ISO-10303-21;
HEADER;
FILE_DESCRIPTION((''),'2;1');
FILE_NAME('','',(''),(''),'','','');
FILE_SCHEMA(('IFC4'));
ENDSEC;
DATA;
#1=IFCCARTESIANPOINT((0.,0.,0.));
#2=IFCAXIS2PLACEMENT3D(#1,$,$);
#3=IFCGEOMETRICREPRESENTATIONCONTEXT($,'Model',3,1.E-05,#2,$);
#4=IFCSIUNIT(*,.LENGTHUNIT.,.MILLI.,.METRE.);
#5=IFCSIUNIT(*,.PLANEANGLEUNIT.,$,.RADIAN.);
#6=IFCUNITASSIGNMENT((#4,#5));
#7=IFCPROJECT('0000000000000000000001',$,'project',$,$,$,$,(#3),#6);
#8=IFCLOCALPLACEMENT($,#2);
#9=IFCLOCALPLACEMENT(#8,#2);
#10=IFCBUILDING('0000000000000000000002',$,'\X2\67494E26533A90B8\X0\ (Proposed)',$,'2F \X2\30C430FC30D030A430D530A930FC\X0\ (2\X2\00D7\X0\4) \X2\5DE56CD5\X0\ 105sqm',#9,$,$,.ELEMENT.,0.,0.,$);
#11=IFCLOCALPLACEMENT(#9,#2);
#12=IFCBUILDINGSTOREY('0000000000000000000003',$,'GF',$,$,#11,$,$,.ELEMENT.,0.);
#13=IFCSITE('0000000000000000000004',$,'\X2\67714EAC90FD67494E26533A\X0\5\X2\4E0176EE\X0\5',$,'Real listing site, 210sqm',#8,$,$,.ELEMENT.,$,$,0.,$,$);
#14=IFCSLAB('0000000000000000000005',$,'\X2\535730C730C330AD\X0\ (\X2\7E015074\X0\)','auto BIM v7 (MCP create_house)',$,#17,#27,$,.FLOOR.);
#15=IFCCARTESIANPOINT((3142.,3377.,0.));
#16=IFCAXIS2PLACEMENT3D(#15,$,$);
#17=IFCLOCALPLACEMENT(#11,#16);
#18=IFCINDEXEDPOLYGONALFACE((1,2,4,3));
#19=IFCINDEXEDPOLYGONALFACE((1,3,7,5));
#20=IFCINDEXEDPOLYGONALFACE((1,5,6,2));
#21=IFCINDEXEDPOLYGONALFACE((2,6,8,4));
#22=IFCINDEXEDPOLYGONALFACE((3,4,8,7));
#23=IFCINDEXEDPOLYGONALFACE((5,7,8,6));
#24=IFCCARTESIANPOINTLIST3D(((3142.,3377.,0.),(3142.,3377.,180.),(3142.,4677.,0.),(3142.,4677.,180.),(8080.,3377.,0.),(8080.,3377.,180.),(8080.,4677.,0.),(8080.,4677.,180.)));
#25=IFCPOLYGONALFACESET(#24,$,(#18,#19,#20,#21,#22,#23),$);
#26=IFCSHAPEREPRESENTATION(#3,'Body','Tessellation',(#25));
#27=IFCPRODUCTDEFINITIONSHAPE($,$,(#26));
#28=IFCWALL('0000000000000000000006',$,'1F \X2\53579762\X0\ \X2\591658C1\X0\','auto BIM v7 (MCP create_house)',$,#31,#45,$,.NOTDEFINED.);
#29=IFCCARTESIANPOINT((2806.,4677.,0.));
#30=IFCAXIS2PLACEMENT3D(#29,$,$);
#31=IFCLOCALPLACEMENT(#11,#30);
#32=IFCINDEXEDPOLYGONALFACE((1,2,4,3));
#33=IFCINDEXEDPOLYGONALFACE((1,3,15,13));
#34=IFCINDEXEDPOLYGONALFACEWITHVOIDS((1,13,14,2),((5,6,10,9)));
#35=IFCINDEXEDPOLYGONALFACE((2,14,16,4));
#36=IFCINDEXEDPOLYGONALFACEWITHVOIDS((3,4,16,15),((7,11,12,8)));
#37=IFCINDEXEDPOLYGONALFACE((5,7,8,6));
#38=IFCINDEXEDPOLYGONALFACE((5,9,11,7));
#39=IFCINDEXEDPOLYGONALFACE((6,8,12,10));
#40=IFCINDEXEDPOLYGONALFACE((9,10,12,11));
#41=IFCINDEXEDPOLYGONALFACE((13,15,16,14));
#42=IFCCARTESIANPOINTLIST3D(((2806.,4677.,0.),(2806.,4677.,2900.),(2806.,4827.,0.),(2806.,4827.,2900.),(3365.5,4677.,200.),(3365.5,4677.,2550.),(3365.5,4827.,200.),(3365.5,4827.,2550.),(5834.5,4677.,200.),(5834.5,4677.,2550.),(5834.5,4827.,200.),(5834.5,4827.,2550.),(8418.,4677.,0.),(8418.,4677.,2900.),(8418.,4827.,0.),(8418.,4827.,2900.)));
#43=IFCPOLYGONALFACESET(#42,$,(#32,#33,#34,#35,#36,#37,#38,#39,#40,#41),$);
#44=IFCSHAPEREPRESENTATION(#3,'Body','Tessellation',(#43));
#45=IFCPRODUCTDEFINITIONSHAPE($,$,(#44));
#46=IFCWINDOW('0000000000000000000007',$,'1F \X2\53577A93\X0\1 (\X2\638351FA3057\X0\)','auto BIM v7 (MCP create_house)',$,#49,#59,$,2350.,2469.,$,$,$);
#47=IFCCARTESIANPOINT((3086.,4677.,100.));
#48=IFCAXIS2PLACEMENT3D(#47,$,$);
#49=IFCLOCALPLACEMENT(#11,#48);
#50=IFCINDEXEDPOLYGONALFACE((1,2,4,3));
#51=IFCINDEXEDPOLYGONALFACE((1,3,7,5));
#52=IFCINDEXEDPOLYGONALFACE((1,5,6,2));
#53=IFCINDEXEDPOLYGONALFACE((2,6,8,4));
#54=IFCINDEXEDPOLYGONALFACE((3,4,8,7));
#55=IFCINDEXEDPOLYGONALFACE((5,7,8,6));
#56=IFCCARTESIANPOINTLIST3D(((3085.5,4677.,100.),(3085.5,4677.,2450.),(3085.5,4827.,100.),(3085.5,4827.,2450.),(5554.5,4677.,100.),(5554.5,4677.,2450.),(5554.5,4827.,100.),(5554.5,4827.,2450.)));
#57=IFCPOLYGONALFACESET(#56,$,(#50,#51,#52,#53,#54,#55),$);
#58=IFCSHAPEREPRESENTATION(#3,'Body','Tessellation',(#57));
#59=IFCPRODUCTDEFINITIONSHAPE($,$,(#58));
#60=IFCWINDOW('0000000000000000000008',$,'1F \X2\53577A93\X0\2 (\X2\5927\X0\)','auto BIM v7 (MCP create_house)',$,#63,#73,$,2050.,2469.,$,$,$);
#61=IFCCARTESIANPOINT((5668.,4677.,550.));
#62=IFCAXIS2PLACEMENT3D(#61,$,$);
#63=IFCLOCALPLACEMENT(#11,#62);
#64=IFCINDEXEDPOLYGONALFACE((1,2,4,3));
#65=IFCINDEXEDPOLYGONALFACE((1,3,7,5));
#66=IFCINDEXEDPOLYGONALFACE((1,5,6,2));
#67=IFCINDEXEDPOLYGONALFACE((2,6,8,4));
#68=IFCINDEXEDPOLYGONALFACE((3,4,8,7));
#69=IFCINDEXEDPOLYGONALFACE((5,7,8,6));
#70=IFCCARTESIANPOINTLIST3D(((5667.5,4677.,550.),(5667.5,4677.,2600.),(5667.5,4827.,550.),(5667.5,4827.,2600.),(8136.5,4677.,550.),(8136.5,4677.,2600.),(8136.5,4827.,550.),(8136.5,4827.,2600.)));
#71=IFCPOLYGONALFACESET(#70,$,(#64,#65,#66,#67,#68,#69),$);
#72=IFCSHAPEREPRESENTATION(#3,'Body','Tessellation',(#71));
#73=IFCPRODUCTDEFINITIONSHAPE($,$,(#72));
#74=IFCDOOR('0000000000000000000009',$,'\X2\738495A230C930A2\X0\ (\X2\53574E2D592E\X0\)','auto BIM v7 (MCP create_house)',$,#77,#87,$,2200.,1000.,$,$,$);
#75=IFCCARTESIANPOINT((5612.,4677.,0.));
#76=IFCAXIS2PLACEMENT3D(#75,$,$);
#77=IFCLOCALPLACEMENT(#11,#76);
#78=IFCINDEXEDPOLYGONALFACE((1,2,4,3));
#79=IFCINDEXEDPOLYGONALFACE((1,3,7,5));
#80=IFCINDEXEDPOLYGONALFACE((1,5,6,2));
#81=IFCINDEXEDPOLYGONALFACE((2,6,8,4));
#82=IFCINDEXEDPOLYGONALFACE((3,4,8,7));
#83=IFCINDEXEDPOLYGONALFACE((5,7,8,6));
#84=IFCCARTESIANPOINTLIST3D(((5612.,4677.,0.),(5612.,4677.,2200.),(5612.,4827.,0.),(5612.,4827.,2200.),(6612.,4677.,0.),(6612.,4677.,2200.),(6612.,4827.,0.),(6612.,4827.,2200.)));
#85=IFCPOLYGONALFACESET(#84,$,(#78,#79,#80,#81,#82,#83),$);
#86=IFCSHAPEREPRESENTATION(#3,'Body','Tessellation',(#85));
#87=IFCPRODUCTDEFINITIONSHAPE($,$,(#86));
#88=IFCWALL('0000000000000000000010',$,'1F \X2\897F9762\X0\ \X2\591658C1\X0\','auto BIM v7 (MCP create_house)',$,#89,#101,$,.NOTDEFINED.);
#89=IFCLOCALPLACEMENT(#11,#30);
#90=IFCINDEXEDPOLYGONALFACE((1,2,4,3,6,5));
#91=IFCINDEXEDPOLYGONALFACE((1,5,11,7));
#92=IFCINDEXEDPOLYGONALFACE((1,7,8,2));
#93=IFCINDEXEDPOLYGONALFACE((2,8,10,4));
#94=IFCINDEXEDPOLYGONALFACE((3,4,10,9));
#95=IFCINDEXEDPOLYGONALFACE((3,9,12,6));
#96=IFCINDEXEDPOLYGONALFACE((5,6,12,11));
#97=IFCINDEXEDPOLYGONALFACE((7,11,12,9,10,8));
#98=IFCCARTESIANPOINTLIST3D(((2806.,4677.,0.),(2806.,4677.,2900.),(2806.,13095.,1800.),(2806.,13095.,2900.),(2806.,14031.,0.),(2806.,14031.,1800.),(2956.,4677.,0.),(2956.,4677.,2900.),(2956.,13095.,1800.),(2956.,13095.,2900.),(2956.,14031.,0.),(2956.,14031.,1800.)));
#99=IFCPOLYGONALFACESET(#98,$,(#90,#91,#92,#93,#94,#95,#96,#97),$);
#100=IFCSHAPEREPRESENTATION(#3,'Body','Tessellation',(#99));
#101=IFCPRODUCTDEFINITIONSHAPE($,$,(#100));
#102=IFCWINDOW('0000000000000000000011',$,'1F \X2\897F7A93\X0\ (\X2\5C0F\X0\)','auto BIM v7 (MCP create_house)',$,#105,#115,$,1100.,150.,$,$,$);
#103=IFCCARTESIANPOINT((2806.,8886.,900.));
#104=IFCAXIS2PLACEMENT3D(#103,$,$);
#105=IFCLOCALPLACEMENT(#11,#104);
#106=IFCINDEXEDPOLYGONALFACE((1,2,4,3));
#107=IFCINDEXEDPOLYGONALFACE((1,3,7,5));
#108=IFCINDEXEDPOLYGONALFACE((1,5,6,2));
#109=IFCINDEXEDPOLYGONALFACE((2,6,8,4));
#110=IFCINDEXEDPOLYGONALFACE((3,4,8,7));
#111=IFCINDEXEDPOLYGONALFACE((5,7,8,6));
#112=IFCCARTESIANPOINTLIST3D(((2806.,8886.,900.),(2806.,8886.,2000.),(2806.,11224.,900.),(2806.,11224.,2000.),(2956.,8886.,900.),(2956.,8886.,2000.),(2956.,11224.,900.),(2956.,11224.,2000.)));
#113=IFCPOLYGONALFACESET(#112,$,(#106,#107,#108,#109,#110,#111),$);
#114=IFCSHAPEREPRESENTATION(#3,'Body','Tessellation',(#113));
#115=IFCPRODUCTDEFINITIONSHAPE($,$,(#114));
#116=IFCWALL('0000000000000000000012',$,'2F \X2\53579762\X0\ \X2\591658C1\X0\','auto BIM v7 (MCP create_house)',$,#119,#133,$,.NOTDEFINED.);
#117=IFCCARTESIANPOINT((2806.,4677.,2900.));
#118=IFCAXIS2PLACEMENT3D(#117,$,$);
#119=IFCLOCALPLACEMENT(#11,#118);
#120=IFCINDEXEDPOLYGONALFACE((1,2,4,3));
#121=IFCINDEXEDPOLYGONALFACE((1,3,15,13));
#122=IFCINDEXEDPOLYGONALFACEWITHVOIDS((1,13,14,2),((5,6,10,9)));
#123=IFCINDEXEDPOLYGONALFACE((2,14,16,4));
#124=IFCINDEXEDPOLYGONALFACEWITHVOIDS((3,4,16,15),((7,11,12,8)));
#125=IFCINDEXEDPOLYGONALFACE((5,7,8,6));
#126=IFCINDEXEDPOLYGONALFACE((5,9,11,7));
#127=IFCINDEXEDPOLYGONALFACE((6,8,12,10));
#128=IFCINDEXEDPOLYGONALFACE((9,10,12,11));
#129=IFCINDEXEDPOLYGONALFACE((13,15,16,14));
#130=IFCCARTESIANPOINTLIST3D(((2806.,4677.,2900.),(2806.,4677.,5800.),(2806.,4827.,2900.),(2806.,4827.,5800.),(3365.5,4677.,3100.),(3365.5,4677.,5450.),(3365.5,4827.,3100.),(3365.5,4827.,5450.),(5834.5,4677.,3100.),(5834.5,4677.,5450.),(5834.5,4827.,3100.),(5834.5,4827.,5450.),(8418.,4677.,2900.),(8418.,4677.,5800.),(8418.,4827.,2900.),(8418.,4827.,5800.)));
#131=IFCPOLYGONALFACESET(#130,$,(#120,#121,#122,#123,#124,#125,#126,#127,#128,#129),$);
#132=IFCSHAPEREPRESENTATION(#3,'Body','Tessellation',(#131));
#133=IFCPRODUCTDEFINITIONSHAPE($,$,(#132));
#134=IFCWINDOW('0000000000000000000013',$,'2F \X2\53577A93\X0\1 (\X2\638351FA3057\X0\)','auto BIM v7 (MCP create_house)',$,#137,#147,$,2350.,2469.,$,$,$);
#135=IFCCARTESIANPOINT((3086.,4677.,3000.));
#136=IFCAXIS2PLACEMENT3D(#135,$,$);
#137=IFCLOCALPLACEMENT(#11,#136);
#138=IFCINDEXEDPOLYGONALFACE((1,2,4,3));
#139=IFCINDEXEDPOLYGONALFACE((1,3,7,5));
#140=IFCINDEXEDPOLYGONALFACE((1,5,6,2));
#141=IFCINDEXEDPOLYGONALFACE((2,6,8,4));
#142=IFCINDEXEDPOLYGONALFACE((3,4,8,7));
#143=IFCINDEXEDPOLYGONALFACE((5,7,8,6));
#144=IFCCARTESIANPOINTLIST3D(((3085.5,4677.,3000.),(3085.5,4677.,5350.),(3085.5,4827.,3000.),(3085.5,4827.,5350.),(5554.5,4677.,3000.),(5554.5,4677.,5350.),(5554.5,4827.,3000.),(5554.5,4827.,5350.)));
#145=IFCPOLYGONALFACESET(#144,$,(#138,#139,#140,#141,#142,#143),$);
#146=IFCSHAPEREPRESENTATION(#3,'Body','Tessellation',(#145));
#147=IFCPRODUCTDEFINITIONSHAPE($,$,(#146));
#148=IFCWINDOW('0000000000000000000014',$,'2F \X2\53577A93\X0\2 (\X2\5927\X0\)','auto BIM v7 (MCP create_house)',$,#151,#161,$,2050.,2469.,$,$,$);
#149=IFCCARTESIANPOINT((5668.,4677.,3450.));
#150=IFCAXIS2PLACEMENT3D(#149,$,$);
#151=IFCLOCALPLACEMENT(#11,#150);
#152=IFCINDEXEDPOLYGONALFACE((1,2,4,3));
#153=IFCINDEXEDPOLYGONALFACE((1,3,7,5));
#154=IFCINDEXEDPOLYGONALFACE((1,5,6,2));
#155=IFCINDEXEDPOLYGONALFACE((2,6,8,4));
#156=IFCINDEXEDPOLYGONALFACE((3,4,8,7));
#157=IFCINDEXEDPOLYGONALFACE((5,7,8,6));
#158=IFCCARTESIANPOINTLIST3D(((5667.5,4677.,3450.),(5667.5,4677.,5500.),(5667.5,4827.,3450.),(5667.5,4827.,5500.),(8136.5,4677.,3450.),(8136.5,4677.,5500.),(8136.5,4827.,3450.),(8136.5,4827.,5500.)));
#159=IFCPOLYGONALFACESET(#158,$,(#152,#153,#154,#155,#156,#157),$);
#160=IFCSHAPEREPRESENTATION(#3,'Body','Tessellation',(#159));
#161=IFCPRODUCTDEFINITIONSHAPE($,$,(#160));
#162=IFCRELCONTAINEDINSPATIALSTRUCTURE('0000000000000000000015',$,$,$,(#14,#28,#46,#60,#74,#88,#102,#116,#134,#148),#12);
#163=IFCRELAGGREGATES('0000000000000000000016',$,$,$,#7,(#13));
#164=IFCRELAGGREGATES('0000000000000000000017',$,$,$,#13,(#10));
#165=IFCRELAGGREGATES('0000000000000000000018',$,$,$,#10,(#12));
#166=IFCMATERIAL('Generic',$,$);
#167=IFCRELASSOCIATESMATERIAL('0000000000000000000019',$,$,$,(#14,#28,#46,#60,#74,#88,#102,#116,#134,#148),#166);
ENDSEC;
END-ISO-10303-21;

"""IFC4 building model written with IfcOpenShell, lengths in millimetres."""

from ifc_helpers import new_model, si_unit, frame, frame_2d, origin, place, context, project, spatial, rectangle, extrude, material, element, fill, save


model = new_model("IFC4")

# Units and contexts
model_context = context("Model", 3, precision=1e-05, world=origin())
ifc_project = project(units=[si_unit("LENGTHUNIT", "METRE", prefix="MILLI"), si_unit("PLANEANGLEUNIT", "RADIAN")], contexts=[model_context])

# Site, building, storey
site_placement = place(None, origin())
site = spatial("IfcSite", under=ifc_project, at=site_placement, Name="東京都杉並区5丁目5", ObjectType="Real listing site, 210sqm", CompositionType="ELEMENT", RefElevation=0.0)
building_placement = place(site_placement, origin())
building = spatial("IfcBuilding", under=site, at=building_placement, Name="杉並区邸 (Proposed)", ObjectType="2F ツーバイフォー (2×4) 工法 105sqm", CompositionType="ELEMENT", ElevationOfRefHeight=0.0, ElevationOfTerrain=0.0)
storey_placement = place(building_placement, origin())
storey = spatial("IfcBuildingStorey", under=building, at=storey_placement, Name="GF", CompositionType="ELEMENT", Elevation=0.0)

# Slab
ifc_material = material(Name="Generic")
slab_1_placement = place(storey_placement, frame((3142.0, 3377.0, 0.0)))
element("IfcSlab", 1, at=slab_1_placement, inside=storey, material=ifc_material, Name="南デッキ (縁側)", Description="auto BIM v7 (MCP create_house)", PredefinedType="FLOOR", context=model_context, shape_type="SweptSolid", body=[
    extrude(rectangle(XDim=4938.0, YDim=1300.0, at=frame_2d((2469.0, 650.0))), frame((3142.0, 3377.0, 0.0)), (0.0, 0.0, 1.0), 180.0),
])

# Wall, openings, windows, door
wall_1_placement = place(storey_placement, frame((2806.0, 4677.0, 0.0)))
wall_1 = element("IfcWall", 2, at=wall_1_placement, inside=storey, material=ifc_material, Name="1F 南面 外壁", Description="auto BIM v7 (MCP create_house)", PredefinedType="NOTDEFINED", context=model_context, shape_type="SweptSolid", body=[
    extrude(rectangle(XDim=5612.0, YDim=150.0, at=frame_2d((2806.0, 75.0))), frame((2806.0, 4677.0, 0.0)), (0.0, 0.0, 1.0), 2900.0),
])
opening_1_placement = place(storey_placement, frame((3086.0, 4677.0, 100.0)))
opening_1 = element("IfcOpeningElement", 3, at=opening_1_placement, cuts=wall_1, PredefinedType="NOTDEFINED", context=model_context, shape_type="SweptSolid", body=[
    extrude(rectangle(XDim=2469.0, YDim=150.0, at=frame_2d((1234.0, 75.0))), frame((3086.0, 4677.0, 100.0)), (0.0, 0.0, 1.0), 2350.0),
])
opening_2_placement = place(storey_placement, frame((5668.0, 4677.0, 550.0)))
opening_2 = element("IfcOpeningElement", 4, at=opening_2_placement, cuts=wall_1, PredefinedType="NOTDEFINED", context=model_context, shape_type="SweptSolid", body=[
    extrude(rectangle(XDim=2469.0, YDim=150.0, at=frame_2d((1234.0, 75.0))), frame((5668.0, 4677.0, 550.0)), (0.0, 0.0, 1.0), 2050.0),
])
opening_3_placement = place(storey_placement, frame((5612.0, 4677.0, 0.0)))
opening_3 = element("IfcOpeningElement", 5, at=opening_3_placement, cuts=wall_1, PredefinedType="NOTDEFINED", context=model_context, shape_type="SweptSolid", body=[
    extrude(rectangle(XDim=1000.0, YDim=150.0, at=frame_2d((500.0, 75.0))), frame((5612.0, 4677.0, 0.0)), (0.0, 0.0, 1.0), 2200.0),
])
window_1_placement = place(storey_placement, frame((3086.0, 4677.0, 100.0)))
window_1 = element("IfcWindow", 6, at=window_1_placement, inside=storey, material=ifc_material, Name="1F 南窓1 (掃出し)", Description="auto BIM v7 (MCP create_house)", OverallHeight=2350.0, OverallWidth=2469.0, context=model_context, shape_type="SweptSolid", body=[
    extrude(rectangle(XDim=2469.0, YDim=150.0, at=frame_2d((1234.0, 75.0))), frame((3086.0, 4677.0, 100.0)), (0.0, 0.0, 1.0), 2350.0),
])
fill(opening_1, window_1)
window_2_placement = place(storey_placement, frame((5668.0, 4677.0, 550.0)))
window_2 = element("IfcWindow", 7, at=window_2_placement, inside=storey, material=ifc_material, Name="1F 南窓2 (大)", Description="auto BIM v7 (MCP create_house)", OverallHeight=2050.0, OverallWidth=2469.0, context=model_context, shape_type="SweptSolid", body=[
    extrude(rectangle(XDim=2469.0, YDim=150.0, at=frame_2d((1234.0, 75.0))), frame((5668.0, 4677.0, 550.0)), (0.0, 0.0, 1.0), 2050.0),
])
fill(opening_2, window_2)
door_placement = place(storey_placement, frame((5612.0, 4677.0, 0.0)))
door = element("IfcDoor", 8, at=door_placement, inside=storey, material=ifc_material, Name="玄関ドア (南中央)", Description="auto BIM v7 (MCP create_house)", OverallHeight=2200.0, OverallWidth=1000.0, context=model_context, shape_type="SweptSolid", body=[
    extrude(rectangle(XDim=1000.0, YDim=150.0, at=frame_2d((500.0, 75.0))), frame((5612.0, 4677.0, 0.0)), (0.0, 0.0, 1.0), 2200.0),
])
fill(opening_3, door)

# Wall, opening, window
wall_2_placement = place(storey_placement, frame((2806.0, 4677.0, 0.0)))
wall_2 = element("IfcWall", 9, at=wall_2_placement, inside=storey, material=ifc_material, Name="1F 西面 外壁", Description="auto BIM v7 (MCP create_house)", PredefinedType="NOTDEFINED", context=model_context, shape_type="SweptSolid", body=[
    extrude(rectangle(XDim=150.0, YDim=9354.0, at=frame_2d((75.0, 4677.0))), frame((2806.0, 4677.0, 0.0)), (0.0, 0.0, 1.0), 2900.0),
])
opening_4_placement = place(storey_placement, frame((2806.0, 8886.0, 900.0)))
opening_4 = element("IfcOpeningElement", 10, at=opening_4_placement, cuts=wall_2, PredefinedType="NOTDEFINED", context=model_context, shape_type="SweptSolid", body=[
    extrude(rectangle(XDim=150.0, YDim=2338.0, at=frame_2d((75.0, 1169.0))), frame((2806.0, 8886.0, 900.0)), (0.0, 0.0, 1.0), 1100.0),
])
window_3_placement = place(storey_placement, frame((2806.0, 8886.0, 900.0)))
window_3 = element("IfcWindow", 11, at=window_3_placement, inside=storey, material=ifc_material, Name="1F 西窓 (小)", Description="auto BIM v7 (MCP create_house)", OverallHeight=1100.0, OverallWidth=150.0, context=model_context, shape_type="SweptSolid", body=[
    extrude(rectangle(XDim=150.0, YDim=2338.0, at=frame_2d((75.0, 1169.0))), frame((2806.0, 8886.0, 900.0)), (0.0, 0.0, 1.0), 1100.0),
])
fill(opening_4, window_3)

# Wall, openings, windows
wall_3_placement = place(storey_placement, frame((2806.0, 4677.0, 2900.0)))
wall_3 = element("IfcWall", 12, at=wall_3_placement, inside=storey, material=ifc_material, Name="2F 南面 外壁", Description="auto BIM v7 (MCP create_house)", PredefinedType="NOTDEFINED", context=model_context, shape_type="SweptSolid", body=[
    extrude(rectangle(XDim=5612.0, YDim=150.0, at=frame_2d((2806.0, 75.0))), frame((2806.0, 4677.0, 2900.0)), (0.0, 0.0, 1.0), 2900.0),
])
opening_5_placement = place(storey_placement, frame((3086.0, 4677.0, 3000.0)))
opening_5 = element("IfcOpeningElement", 13, at=opening_5_placement, cuts=wall_3, PredefinedType="NOTDEFINED", context=model_context, shape_type="SweptSolid", body=[
    extrude(rectangle(XDim=2469.0, YDim=150.0, at=frame_2d((1234.0, 75.0))), frame((3086.0, 4677.0, 3000.0)), (0.0, 0.0, 1.0), 2350.0),
])
opening_6_placement = place(storey_placement, frame((5668.0, 4677.0, 3450.0)))
opening_6 = element("IfcOpeningElement", 14, at=opening_6_placement, cuts=wall_3, PredefinedType="NOTDEFINED", context=model_context, shape_type="SweptSolid", body=[
    extrude(rectangle(XDim=2469.0, YDim=150.0, at=frame_2d((1234.0, 75.0))), frame((5668.0, 4677.0, 3450.0)), (0.0, 0.0, 1.0), 2050.0),
])
window_4_placement = place(storey_placement, frame((3086.0, 4677.0, 3000.0)))
window_4 = element("IfcWindow", 15, at=window_4_placement, inside=storey, material=ifc_material, Name="2F 南窓1 (掃出し)", Description="auto BIM v7 (MCP create_house)", OverallHeight=2350.0, OverallWidth=2469.0, context=model_context, shape_type="SweptSolid", body=[
    extrude(rectangle(XDim=2469.0, YDim=150.0, at=frame_2d((1234.0, 75.0))), frame((3086.0, 4677.0, 3000.0)), (0.0, 0.0, 1.0), 2350.0),
])
fill(opening_5, window_4)
window_5_placement = place(storey_placement, frame((5668.0, 4677.0, 3450.0)))
window_5 = element("IfcWindow", 16, at=window_5_placement, inside=storey, material=ifc_material, Name="2F 南窓2 (大)", Description="auto BIM v7 (MCP create_house)", OverallHeight=2050.0, OverallWidth=2469.0, context=model_context, shape_type="SweptSolid", body=[
    extrude(rectangle(XDim=2469.0, YDim=150.0, at=frame_2d((1234.0, 75.0))), frame((5668.0, 4677.0, 3450.0)), (0.0, 0.0, 1.0), 2050.0),
])
fill(opening_6, window_5)

save(model, "model.ifc")
